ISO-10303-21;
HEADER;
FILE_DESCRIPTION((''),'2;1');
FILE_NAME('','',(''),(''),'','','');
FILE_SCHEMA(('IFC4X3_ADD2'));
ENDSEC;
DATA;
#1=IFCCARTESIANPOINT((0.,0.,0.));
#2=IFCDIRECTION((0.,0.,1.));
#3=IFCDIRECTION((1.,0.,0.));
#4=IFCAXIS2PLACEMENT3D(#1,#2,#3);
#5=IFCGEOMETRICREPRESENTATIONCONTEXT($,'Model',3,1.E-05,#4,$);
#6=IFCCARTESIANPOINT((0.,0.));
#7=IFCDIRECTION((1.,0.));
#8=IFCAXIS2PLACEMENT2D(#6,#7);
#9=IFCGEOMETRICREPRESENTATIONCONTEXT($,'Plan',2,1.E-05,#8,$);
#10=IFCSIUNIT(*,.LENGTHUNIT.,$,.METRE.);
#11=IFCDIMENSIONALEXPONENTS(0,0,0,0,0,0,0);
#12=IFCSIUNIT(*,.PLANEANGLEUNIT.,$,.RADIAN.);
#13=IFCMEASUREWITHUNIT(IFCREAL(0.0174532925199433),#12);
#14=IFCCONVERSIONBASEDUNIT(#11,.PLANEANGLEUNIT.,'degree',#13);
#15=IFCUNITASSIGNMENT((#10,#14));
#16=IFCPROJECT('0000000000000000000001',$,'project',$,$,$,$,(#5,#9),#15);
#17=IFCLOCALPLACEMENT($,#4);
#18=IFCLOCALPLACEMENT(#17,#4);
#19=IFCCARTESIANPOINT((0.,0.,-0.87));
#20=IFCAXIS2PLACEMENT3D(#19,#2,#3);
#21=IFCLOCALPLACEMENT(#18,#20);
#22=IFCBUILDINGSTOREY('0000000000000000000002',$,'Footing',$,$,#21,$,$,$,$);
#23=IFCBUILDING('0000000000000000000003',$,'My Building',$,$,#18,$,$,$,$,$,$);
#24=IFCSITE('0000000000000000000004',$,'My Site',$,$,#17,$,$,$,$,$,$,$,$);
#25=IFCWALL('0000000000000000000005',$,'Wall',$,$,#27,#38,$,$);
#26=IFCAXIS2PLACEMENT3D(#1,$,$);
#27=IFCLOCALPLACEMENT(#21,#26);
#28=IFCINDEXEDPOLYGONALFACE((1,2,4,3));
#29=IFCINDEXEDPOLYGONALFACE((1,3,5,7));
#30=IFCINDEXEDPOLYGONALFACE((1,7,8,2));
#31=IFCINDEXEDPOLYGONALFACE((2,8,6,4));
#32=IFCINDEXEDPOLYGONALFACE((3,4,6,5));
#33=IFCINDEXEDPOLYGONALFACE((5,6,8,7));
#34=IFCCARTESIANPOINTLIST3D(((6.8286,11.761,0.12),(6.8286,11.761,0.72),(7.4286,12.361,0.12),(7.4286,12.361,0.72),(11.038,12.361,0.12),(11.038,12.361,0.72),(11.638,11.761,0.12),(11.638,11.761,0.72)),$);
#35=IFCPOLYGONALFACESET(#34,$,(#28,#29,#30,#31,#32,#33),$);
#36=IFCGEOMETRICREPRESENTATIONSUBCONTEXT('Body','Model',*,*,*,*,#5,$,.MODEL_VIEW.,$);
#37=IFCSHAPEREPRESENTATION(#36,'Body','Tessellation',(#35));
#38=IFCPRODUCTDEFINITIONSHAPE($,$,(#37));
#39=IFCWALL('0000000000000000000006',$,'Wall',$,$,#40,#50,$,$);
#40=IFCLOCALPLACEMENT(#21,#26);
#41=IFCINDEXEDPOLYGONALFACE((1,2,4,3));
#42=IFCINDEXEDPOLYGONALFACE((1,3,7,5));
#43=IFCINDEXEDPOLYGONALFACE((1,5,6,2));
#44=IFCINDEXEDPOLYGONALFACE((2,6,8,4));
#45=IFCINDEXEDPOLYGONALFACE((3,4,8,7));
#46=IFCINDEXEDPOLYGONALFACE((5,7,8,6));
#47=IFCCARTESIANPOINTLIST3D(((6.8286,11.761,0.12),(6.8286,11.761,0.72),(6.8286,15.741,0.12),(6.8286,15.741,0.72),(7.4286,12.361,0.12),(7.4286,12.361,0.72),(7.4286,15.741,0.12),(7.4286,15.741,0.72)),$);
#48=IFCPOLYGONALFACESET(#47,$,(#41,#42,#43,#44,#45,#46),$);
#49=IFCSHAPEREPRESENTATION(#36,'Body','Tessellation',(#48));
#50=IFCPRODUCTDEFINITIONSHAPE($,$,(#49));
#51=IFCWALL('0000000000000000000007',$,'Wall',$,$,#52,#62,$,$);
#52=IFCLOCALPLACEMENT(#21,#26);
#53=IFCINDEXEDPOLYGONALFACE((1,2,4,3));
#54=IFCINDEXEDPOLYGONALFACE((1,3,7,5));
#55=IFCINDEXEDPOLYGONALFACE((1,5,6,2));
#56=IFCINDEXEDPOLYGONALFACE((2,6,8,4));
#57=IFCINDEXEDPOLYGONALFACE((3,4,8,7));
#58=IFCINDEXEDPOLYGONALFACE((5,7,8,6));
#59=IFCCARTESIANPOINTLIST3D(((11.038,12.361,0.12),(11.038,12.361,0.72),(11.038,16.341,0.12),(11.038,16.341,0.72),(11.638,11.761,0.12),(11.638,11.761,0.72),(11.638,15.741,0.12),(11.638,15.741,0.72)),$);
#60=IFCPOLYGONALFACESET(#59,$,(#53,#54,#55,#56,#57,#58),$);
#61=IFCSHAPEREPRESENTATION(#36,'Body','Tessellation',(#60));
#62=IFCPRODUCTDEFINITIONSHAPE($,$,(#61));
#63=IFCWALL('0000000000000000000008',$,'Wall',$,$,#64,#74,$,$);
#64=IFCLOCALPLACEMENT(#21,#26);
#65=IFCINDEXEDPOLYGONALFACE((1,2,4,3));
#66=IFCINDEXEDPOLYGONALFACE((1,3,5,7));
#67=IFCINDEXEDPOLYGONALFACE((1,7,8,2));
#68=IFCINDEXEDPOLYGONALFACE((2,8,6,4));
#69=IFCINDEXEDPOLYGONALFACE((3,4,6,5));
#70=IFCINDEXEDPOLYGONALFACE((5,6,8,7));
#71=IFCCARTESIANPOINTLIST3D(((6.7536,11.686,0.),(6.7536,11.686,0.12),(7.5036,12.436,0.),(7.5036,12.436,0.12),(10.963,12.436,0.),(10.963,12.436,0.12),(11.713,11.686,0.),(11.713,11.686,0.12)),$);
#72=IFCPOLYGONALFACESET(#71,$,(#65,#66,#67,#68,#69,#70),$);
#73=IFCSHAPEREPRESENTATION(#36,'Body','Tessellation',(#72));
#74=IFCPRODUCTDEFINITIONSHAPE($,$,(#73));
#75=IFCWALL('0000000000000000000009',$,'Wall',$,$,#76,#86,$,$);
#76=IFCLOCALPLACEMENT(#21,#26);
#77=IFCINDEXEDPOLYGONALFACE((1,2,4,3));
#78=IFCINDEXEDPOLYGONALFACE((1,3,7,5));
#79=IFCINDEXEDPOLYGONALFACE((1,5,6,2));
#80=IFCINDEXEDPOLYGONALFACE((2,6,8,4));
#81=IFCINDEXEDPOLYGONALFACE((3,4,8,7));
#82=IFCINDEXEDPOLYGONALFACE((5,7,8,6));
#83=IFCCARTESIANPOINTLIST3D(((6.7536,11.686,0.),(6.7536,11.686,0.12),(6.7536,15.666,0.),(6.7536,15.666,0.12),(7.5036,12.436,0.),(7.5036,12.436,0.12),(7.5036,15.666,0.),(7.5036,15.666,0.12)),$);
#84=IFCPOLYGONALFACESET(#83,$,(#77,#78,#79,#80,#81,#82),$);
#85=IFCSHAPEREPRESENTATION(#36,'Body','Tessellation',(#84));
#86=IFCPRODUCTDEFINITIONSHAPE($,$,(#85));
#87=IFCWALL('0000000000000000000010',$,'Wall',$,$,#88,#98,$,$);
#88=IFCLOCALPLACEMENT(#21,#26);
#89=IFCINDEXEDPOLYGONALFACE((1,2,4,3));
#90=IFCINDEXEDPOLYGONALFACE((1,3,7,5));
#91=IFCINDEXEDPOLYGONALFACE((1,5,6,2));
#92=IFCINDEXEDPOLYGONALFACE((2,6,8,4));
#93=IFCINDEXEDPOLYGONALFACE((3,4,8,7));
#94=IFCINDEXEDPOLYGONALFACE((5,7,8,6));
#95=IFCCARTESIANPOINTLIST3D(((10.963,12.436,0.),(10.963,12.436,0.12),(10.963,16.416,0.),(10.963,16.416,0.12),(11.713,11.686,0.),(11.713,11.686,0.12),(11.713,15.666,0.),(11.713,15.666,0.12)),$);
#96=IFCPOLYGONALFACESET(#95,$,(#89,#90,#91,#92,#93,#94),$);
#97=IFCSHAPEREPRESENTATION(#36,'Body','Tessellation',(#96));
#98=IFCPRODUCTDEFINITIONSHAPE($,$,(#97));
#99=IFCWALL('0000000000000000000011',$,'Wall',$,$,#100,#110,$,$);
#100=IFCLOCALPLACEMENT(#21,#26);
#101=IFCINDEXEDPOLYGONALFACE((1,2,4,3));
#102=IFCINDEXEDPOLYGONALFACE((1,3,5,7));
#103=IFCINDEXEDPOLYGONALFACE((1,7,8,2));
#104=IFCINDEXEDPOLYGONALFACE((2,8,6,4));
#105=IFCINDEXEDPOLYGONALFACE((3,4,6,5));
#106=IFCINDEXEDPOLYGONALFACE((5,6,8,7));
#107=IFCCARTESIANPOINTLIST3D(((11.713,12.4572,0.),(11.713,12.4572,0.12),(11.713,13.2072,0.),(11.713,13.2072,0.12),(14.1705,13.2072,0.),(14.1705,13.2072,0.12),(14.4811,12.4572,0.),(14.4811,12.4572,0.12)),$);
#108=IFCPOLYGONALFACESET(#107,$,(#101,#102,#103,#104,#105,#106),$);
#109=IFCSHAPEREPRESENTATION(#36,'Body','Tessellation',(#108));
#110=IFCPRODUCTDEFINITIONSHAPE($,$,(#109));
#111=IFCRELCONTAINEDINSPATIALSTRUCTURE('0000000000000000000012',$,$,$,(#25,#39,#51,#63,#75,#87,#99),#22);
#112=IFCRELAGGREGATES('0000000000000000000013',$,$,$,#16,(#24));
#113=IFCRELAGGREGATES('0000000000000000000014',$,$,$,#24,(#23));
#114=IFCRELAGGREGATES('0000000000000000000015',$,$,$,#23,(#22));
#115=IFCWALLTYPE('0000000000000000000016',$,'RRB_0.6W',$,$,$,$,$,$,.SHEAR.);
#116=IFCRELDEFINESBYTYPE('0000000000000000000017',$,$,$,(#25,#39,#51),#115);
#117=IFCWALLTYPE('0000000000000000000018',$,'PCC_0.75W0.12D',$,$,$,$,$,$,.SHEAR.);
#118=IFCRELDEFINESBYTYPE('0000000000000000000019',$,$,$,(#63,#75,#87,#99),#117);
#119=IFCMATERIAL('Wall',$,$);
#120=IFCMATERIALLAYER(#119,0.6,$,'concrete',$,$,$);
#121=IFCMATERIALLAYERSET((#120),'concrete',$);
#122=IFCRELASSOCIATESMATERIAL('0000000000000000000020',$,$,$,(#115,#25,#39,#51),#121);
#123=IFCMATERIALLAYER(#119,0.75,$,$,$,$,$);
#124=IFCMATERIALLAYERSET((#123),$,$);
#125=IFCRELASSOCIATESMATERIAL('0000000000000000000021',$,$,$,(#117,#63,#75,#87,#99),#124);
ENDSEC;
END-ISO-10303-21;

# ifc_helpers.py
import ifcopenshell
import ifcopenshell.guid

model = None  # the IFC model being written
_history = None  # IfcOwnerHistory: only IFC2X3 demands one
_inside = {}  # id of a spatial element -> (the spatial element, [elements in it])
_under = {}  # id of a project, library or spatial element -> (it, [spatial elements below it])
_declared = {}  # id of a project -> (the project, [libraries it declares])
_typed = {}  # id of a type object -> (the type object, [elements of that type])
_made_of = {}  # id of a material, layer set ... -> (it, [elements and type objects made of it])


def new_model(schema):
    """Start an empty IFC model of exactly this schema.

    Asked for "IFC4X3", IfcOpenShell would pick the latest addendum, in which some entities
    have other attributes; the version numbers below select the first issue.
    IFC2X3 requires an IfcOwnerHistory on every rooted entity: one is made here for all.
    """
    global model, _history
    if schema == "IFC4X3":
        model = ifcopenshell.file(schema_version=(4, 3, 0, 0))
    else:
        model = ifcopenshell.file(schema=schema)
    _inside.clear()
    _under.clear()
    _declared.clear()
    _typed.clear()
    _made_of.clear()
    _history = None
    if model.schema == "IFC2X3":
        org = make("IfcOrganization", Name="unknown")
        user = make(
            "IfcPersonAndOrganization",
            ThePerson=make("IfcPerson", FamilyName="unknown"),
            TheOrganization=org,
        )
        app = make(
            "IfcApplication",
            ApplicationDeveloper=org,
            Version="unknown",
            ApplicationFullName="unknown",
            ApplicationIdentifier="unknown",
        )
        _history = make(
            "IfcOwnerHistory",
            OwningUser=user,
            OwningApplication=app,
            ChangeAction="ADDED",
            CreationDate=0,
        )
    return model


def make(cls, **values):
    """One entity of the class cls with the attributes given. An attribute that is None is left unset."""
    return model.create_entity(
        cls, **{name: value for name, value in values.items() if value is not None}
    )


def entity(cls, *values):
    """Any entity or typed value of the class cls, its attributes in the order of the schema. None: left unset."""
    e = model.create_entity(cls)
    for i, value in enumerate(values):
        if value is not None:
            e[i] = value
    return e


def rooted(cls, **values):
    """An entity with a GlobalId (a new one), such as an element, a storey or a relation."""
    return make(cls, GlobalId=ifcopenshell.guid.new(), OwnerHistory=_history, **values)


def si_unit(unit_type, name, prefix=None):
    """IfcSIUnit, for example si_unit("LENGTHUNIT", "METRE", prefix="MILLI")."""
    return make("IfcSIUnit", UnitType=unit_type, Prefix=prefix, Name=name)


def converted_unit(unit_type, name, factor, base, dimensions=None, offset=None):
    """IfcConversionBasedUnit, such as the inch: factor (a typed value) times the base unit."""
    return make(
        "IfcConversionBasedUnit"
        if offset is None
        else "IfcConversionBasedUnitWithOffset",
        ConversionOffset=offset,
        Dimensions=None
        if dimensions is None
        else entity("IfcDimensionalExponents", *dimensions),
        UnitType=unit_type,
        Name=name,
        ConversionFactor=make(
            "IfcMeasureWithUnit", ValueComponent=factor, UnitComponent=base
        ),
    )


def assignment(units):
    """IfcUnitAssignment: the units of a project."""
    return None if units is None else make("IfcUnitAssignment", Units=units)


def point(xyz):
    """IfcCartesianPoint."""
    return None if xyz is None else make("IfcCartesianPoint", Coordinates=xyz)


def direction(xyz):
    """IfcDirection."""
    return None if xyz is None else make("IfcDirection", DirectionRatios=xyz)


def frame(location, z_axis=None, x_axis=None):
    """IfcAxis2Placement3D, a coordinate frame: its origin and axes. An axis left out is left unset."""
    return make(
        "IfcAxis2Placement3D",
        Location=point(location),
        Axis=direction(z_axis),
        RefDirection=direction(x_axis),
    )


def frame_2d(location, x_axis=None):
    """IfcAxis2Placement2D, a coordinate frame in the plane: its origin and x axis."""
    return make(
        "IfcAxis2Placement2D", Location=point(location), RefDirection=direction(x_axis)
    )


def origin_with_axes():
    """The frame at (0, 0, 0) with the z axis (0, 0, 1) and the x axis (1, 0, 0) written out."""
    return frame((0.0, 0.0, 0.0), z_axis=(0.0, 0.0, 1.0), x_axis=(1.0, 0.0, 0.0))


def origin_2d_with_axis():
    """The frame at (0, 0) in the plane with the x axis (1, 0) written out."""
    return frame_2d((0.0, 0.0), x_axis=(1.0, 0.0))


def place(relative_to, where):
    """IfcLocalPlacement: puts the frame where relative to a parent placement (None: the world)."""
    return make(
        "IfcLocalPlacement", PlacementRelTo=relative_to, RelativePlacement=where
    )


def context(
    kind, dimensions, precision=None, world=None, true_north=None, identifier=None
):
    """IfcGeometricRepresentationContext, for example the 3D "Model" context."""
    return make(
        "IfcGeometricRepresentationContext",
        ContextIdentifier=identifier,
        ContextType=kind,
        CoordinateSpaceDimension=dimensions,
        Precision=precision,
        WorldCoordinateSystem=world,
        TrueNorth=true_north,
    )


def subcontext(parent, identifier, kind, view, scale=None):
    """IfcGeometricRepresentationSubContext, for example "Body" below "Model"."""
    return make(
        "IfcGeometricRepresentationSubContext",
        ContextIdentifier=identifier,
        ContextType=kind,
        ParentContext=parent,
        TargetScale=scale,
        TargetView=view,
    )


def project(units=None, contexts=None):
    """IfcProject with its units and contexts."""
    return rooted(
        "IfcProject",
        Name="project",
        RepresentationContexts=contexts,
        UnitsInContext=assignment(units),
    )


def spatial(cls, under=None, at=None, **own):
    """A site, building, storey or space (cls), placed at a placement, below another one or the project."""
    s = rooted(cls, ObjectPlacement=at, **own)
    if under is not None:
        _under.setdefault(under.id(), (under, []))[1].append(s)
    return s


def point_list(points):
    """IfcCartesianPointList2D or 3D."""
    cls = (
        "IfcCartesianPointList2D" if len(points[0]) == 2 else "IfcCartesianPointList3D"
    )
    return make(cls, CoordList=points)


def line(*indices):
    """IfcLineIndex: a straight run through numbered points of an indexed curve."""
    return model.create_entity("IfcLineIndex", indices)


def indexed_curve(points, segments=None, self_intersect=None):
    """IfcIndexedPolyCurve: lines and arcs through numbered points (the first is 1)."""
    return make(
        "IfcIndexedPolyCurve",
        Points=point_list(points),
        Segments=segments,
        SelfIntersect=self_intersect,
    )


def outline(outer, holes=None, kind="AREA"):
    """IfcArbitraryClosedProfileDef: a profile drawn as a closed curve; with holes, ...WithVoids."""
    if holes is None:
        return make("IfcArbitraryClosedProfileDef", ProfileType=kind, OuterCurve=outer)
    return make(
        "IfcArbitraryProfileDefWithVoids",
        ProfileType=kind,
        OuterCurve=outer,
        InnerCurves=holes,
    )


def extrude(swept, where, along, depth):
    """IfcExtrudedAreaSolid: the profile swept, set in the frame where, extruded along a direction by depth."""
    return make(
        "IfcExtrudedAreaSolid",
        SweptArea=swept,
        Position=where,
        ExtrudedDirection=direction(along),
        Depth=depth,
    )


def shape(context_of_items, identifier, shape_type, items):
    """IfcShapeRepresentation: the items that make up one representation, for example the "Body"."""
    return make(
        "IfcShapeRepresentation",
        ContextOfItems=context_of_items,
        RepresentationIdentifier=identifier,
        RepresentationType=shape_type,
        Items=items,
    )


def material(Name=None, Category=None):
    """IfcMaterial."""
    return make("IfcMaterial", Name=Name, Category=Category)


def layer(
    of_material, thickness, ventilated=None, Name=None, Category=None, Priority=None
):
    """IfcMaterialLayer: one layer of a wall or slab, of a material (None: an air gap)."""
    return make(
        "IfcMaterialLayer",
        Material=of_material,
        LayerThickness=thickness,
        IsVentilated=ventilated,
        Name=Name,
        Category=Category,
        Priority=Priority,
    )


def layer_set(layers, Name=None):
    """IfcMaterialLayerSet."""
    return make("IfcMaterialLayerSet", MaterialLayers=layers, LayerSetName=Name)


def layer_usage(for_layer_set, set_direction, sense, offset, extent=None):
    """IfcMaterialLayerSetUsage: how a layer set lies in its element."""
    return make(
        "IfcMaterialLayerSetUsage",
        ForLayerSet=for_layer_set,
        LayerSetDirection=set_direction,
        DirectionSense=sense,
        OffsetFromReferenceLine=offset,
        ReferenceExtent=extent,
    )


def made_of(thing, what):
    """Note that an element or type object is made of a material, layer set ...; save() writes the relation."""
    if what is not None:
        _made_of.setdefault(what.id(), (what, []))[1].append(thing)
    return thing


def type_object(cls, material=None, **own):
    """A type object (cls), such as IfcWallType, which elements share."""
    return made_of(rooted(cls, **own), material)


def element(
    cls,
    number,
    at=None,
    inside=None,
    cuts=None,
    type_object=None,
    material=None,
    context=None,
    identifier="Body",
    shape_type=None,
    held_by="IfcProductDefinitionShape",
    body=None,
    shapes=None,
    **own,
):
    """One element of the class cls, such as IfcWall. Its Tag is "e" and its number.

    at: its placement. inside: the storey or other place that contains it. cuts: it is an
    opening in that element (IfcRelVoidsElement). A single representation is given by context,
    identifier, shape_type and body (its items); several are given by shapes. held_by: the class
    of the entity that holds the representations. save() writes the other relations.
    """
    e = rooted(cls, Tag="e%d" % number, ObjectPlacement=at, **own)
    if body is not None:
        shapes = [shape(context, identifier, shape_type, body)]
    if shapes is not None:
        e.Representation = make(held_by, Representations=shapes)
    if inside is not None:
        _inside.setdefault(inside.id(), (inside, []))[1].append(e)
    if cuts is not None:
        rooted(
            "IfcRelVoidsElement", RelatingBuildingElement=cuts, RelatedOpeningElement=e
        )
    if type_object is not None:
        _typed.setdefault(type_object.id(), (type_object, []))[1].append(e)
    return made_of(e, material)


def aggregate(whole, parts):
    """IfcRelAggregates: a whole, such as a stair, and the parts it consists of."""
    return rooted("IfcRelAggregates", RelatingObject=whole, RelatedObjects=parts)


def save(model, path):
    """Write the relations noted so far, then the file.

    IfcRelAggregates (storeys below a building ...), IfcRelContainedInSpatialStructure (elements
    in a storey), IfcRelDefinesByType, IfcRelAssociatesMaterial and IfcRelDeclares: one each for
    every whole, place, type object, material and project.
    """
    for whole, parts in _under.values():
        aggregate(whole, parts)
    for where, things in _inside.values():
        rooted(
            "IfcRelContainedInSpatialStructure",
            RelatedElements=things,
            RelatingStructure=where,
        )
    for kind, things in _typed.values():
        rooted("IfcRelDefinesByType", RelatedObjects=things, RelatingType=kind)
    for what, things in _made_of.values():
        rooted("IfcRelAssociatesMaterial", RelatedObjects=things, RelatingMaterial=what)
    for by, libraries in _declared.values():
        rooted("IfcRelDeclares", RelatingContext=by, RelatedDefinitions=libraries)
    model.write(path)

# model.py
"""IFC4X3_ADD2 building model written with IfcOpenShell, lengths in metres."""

from ifc_helpers import new_model, entity, si_unit, converted_unit, frame, origin_with_axes, origin_2d_with_axis, place, context, subcontext, project, spatial, line, indexed_curve, outline, extrude, material, layer, layer_set, layer_usage, type_object, element, save


model = new_model("IFC4X3_ADD2")

# Units and contexts
model_context = context("Model", 3, precision=1e-05, world=origin_with_axes())
plan_context = context("Plan", 2, precision=1e-05, world=origin_2d_with_axis())
body_context = subcontext(model_context, "Body", "Model", "MODEL_VIEW")
ifc_project = project(units=[si_unit("LENGTHUNIT", "METRE"), converted_unit("PLANEANGLEUNIT", "degree", entity("IfcReal", 0.0174532925199433), si_unit("PLANEANGLEUNIT", "RADIAN"), dimensions=[0, 0, 0, 0, 0, 0, 0])], contexts=[model_context, plan_context])

# Site, building, storey
site_placement = place(None, origin_with_axes())
site = spatial("IfcSite", under=ifc_project, at=site_placement, Name="My Site")
building_placement = place(site_placement, origin_with_axes())
building = spatial("IfcBuilding", under=site, at=building_placement, Name="My Building")
storey_placement = place(building_placement, frame((0.0, 0.0, -0.87), z_axis=(0.0, 0.0, 1.0), x_axis=(1.0, 0.0, 0.0)))
storey = spatial("IfcBuildingStorey", under=building, at=storey_placement, Name="Footing")

# Walls
ifc_material_1 = material(Name="Wall")
ifc_layer_1 = layer(ifc_material_1, 0.6, Name="concrete")
ifc_layer_set_1 = layer_set([ifc_layer_1], Name="concrete")
ifc_layer_usage_1 = layer_usage(ifc_layer_set_1, "AXIS2", "POSITIVE", 0.0)
wall_type_1 = type_object("IfcWallType", Name="RRB_0.6W", PredefinedType="SHEAR", material=ifc_layer_set_1)
wall_1_placement = place(storey_placement, frame((11.638, 12.361, 0.12), z_axis=(0.0, 0.0, 1.0), x_axis=(-1.0, 0.0, 0.0)))
element("IfcWall", 1, at=wall_1_placement, inside=storey, type_object=wall_type_1, material=ifc_layer_usage_1, Name="Wall", context=body_context, shape_type="SweptSolid", body=[
    extrude(outline(indexed_curve([(0.6, 0.0), (0.0, 0.6), (4.8094, 0.6), (4.2094, 0.0)], segments=[line(1, 2, 3, 4, 1)])), origin_with_axes(), (0.0, 0.0, 1.0), 0.6),
])
ifc_layer_usage_2 = layer_usage(ifc_layer_set_1, "AXIS2", "POSITIVE", 0.0)
wall_2_placement = place(storey_placement, frame((7.4286, 12.361, 0.12), z_axis=(0.0, 0.0, 1.0), x_axis=(0.0, 1.0, 0.0)))
element("IfcWall", 2, at=wall_2_placement, inside=storey, type_object=wall_type_1, material=ifc_layer_usage_2, Name="Wall", context=body_context, shape_type="SweptSolid", body=[
    extrude(outline(indexed_curve([(0.0, 0.0), (-0.6, 0.6), (3.38, 0.6), (3.38, 0.0)], segments=[line(1, 2, 3, 4, 1)])), origin_with_axes(), (0.0, 0.0, 1.0), 0.6),
])
ifc_layer_usage_3 = layer_usage(ifc_layer_set_1, "AXIS2", "POSITIVE", 0.0)
wall_3_placement = place(storey_placement, frame((11.638, 12.361, 0.12), z_axis=(0.0, 0.0, 1.0), x_axis=(0.0, 1.0, 0.0)))
element("IfcWall", 3, at=wall_3_placement, inside=storey, type_object=wall_type_1, material=ifc_layer_usage_3, Name="Wall", context=body_context, shape_type="SweptSolid", body=[
    extrude(outline(indexed_curve([(-0.6, 0.0), (0.0, 0.6), (3.98, 0.6), (3.38, 0.0)], segments=[line(1, 2, 3, 4, 1)])), origin_with_axes(), (0.0, 0.0, 1.0), 0.6),
])
ifc_layer_2 = layer(ifc_material_1, 0.75)
ifc_layer_set_2 = layer_set([ifc_layer_2])
ifc_layer_usage_4 = layer_usage(ifc_layer_set_2, "AXIS2", "POSITIVE", 0.0)
wall_type_2 = type_object("IfcWallType", Name="PCC_0.75W0.12D", PredefinedType="SHEAR", material=ifc_layer_set_2)
wall_4_placement = place(storey_placement, frame((11.713, 12.436, 0.0), z_axis=(0.0, 0.0, 1.0), x_axis=(-1.0, 0.0, 0.0)))
element("IfcWall", 4, at=wall_4_placement, inside=storey, type_object=wall_type_2, material=ifc_layer_usage_4, Name="Wall", context=body_context, shape_type="SweptSolid", body=[
    extrude(outline(indexed_curve([(0.75, 0.0), (0.0, 0.75), (4.9594, 0.75), (4.2094, 0.0)], segments=[line(1, 2, 3, 4, 1)])), origin_with_axes(), (0.0, 0.0, 1.0), 0.12),
])
ifc_layer_usage_5 = layer_usage(ifc_layer_set_2, "AXIS2", "POSITIVE", 0.0)
wall_5_placement = place(storey_placement, frame((7.5036, 12.436, 0.0), z_axis=(0.0, 0.0, 1.0), x_axis=(0.0, 1.0, 0.0)))
element("IfcWall", 5, at=wall_5_placement, inside=storey, type_object=wall_type_2, material=ifc_layer_usage_5, Name="Wall", context=body_context, shape_type="SweptSolid", body=[
    extrude(outline(indexed_curve([(0.0, 0.0), (-0.75, 0.75), (3.23, 0.75), (3.23, 0.0)], segments=[line(1, 2, 3, 4, 1)])), origin_with_axes(), (0.0, 0.0, 1.0), 0.12),
])
ifc_layer_usage_6 = layer_usage(ifc_layer_set_2, "AXIS2", "POSITIVE", 0.0)
wall_6_placement = place(storey_placement, frame((11.713, 12.436, 0.0), z_axis=(0.0, 0.0, 1.0), x_axis=(0.0, 1.0, 0.0)))
element("IfcWall", 6, at=wall_6_placement, inside=storey, type_object=wall_type_2, material=ifc_layer_usage_6, Name="Wall", context=body_context, shape_type="SweptSolid", body=[
    extrude(outline(indexed_curve([(-0.75, 0.0), (0.0, 0.75), (3.98, 0.75), (3.23, 0.0)], segments=[line(1, 2, 3, 4, 1)])), origin_with_axes(), (0.0, 0.0, 1.0), 0.12),
])
ifc_layer_usage_7 = layer_usage(ifc_layer_set_2, "AXIS2", "POSITIVE", 0.0)
wall_7_placement = place(storey_placement, frame((11.713, 12.4572, 0.0), z_axis=(0.0, 0.0, 1.0), x_axis=(1.0, -0.000001, 0.0)))
element("IfcWall", 7, at=wall_7_placement, inside=storey, type_object=wall_type_2, material=ifc_layer_usage_7, Name="Wall", context=body_context, shape_type="SweptSolid", body=[
    extrude(outline(indexed_curve([(0.0, 0.0), (0.0, 0.75), (2.4575, 0.75), (2.7681, 0.0)], segments=[line(1, 2, 3, 4, 1)])), origin_with_axes(), (0.0, 0.0, 1.0), 0.12),
])

save(model, "model.ifc")
